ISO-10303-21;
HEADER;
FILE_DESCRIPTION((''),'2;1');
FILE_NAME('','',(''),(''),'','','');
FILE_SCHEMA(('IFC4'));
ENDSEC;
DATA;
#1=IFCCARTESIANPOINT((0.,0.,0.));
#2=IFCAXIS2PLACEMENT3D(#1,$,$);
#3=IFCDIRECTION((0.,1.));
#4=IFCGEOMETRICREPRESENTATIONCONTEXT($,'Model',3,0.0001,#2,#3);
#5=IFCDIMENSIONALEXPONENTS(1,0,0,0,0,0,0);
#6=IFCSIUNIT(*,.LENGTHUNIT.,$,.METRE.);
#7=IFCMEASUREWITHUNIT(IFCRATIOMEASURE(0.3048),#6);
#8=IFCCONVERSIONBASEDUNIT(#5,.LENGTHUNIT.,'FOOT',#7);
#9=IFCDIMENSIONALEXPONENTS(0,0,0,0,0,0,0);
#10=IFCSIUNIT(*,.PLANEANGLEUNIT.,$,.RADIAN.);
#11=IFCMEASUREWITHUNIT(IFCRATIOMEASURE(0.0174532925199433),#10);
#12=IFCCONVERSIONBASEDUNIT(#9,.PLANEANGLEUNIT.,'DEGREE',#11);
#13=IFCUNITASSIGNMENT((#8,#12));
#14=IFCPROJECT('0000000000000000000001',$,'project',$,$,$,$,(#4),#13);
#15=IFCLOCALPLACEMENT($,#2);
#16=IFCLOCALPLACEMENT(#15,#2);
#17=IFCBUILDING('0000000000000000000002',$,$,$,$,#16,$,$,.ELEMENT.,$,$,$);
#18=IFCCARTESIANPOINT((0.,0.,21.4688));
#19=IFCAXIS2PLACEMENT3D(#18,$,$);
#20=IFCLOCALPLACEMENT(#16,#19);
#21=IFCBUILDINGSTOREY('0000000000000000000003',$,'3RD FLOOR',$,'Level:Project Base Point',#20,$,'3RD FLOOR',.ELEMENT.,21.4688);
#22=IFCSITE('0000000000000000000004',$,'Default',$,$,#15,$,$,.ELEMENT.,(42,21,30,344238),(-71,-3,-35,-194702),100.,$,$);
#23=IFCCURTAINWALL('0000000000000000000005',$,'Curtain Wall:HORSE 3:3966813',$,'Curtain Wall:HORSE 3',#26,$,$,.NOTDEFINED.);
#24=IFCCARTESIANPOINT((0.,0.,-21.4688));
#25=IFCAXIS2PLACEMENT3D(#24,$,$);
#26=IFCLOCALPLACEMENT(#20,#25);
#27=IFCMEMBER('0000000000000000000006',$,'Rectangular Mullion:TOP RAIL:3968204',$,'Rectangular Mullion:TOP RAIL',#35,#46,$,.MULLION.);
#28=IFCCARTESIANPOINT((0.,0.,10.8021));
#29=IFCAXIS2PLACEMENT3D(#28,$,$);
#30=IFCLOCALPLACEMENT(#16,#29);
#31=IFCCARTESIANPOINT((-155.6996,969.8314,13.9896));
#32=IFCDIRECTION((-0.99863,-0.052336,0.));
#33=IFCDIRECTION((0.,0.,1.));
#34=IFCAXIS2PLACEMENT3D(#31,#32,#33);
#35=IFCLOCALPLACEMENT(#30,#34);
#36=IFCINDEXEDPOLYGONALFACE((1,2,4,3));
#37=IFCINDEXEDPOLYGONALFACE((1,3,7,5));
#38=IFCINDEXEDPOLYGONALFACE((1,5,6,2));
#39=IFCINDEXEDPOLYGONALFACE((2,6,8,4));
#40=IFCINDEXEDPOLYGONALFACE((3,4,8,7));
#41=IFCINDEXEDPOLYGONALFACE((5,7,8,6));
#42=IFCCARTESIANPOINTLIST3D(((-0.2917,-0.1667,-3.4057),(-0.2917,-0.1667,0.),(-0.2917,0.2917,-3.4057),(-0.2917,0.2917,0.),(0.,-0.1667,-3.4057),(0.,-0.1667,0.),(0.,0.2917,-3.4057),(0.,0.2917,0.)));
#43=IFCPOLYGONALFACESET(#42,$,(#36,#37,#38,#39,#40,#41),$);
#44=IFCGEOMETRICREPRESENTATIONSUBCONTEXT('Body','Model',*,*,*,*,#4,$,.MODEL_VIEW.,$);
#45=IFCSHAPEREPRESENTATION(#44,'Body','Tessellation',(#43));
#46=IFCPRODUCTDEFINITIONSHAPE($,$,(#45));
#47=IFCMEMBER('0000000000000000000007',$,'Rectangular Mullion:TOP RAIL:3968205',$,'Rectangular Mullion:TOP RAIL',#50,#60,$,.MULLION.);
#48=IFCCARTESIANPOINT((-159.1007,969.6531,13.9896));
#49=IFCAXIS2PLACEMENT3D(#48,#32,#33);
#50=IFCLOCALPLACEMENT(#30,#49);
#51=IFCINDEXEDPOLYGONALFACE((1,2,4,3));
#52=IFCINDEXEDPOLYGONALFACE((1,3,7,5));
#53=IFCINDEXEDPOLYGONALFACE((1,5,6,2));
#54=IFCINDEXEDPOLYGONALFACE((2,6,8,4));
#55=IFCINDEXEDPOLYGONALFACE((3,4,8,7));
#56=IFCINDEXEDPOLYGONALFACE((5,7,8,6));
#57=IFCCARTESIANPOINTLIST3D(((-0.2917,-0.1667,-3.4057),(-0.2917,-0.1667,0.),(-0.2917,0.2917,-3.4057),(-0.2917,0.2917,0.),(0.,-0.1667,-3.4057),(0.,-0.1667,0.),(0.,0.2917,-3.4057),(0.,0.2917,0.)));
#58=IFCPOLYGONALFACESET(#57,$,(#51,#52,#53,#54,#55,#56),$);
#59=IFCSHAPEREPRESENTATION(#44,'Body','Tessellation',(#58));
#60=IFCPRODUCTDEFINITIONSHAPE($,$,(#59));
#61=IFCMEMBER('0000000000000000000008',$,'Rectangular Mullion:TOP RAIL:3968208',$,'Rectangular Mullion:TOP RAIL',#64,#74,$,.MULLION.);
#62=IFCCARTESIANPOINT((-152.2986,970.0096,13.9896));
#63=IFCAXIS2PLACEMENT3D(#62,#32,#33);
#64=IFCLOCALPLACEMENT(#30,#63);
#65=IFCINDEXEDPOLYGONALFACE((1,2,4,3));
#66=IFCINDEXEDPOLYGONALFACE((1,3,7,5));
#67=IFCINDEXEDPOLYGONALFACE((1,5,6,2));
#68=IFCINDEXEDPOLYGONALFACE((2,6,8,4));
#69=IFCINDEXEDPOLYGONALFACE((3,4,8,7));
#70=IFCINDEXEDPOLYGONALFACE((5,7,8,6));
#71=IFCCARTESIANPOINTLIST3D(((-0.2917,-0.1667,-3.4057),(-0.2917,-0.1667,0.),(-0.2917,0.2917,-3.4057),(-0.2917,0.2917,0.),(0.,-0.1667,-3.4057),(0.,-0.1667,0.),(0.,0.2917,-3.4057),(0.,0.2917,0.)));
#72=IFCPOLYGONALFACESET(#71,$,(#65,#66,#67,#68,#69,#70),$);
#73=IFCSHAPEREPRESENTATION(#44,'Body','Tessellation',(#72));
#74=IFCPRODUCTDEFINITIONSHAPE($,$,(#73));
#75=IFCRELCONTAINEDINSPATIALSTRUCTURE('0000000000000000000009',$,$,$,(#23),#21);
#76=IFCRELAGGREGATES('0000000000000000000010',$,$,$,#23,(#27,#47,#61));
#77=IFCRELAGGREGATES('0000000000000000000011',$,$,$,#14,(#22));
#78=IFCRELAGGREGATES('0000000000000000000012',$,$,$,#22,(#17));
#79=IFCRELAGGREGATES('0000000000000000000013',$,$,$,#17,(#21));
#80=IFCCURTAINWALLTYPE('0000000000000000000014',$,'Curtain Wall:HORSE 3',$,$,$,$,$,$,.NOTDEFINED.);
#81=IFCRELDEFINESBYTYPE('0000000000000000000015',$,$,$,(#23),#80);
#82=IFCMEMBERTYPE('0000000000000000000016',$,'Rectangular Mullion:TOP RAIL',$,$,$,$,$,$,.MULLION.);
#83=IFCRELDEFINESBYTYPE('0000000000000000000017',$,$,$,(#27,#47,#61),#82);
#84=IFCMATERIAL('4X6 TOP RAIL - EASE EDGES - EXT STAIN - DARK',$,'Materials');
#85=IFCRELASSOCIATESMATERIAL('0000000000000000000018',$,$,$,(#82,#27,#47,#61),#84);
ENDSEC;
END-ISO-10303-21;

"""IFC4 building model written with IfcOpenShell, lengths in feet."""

from ifc_helpers import new_model, entity, si_unit, converted_unit, direction, frame, origin, origin_2d_with_axis, place, context, subcontext, project, spatial, rectangle, extrude, source, transform, mapped, material, material_profile, profile_set, profile_usage, type_object, type_shapes, element, aggregate, save


model = new_model("IFC4")

# Units and contexts
model_context = context("Model", 3, precision=0.0001, world=origin(), true_north=direction((0.0, 1.0)))
body_context = subcontext(model_context, "Body", "Model", "MODEL_VIEW")
ifc_project = project(units=[converted_unit("LENGTHUNIT", "FOOT", entity("IfcRatioMeasure", 0.3048), si_unit("LENGTHUNIT", "METRE"), dimensions=[1, 0, 0, 0, 0, 0, 0]), converted_unit("PLANEANGLEUNIT", "DEGREE", entity("IfcRatioMeasure", 0.0174532925199433), si_unit("PLANEANGLEUNIT", "RADIAN"), dimensions=[0, 0, 0, 0, 0, 0, 0])], contexts=[model_context])

# Site, building, storey
site_placement = place(None, origin())
site = spatial("IfcSite", under=ifc_project, at=site_placement, Name="Default", CompositionType="ELEMENT", RefLatitude=(42, 21, 30, 344238), RefLongitude=(-71, -3, -35, -194702), RefElevation=100.0)
building_placement = place(site_placement, origin())
building = spatial("IfcBuilding", under=site, at=building_placement, CompositionType="ELEMENT")
storey_placement = place(building_placement, frame((0.0, 0.0, 21.4688)))
storey = spatial("IfcBuildingStorey", under=building, at=storey_placement, Name="3RD FLOOR", ObjectType="Level:Project Base Point", LongName="3RD FLOOR", CompositionType="ELEMENT", Elevation=21.4688)

# Curtain wall
curtain_wall_type_1 = type_object("IfcCurtainWallType", Name="Curtain Wall:HORSE 3", PredefinedType="NOTDEFINED")
curtain_wall_1_placement = place(storey_placement, frame((0.0, 0.0, -21.4688)))
curtain_wall_1 = element("IfcCurtainWall", 1, at=curtain_wall_1_placement, inside=storey, type_object=curtain_wall_type_1, Name="Curtain Wall:HORSE 3:3966813", ObjectType="Curtain Wall:HORSE 3", PredefinedType="NOTDEFINED")

# Members
ifc_material_1 = material(Name="4X6 TOP RAIL - EASE EDGES - EXT STAIN - DARK", Category="Materials")
ifc_material_profile_1 = material_profile(ifc_material_1, rectangle(XDim=0.4583, YDim=0.2917, at=origin_2d_with_axis()), Name="TOP RAIL")
ifc_profile_set_1 = profile_set([ifc_material_profile_1], Name="TOP RAIL")
ifc_profile_usage_1 = profile_usage(ifc_profile_set_1)
member_type_1 = type_object("IfcMemberType", Name="Rectangular Mullion:TOP RAIL", PredefinedType="MULLION", material=ifc_profile_set_1)
shared_shape_1 = source(origin(), body_context, "Body", "SweptSolid", [
    extrude(rectangle(XDim=0.4583, YDim=0.2917, at=origin_2d_with_axis()), frame((-0.1458, 0.0625, -3.4057), z_axis=(0.0, 0.0, 1.0), x_axis=(0.0, -1.0, 0.0)), (0.0, 0.0, 1.0), 3.4057),
])
type_shapes(member_type_1, [shared_shape_1])
placement = place(building_placement, frame((0.0, 0.0, 10.8021)))
member_1_placement = place(placement, frame((-155.6996, 969.8314, 13.9896), z_axis=(-0.99863, -0.052336, 0.0), x_axis=(0.0, 0.0, 1.0)))
member_1 = element("IfcMember", 2, at=member_1_placement, type_object=member_type_1, material=ifc_profile_usage_1, Name="Rectangular Mullion:TOP RAIL:3968204", ObjectType="Rectangular Mullion:TOP RAIL", PredefinedType="MULLION", context=body_context, shape_type="MappedRepresentation", body=[
    mapped(shared_shape_1, transform((0.0, 0.0, 0.0), scale=1.0)),
])
ifc_profile_usage_2 = profile_usage(ifc_profile_set_1)
member_2_placement = place(placement, frame((-159.1007, 969.6531, 13.9896), z_axis=(-0.99863, -0.052336, 0.0), x_axis=(0.0, 0.0, 1.0)))
member_2 = element("IfcMember", 3, at=member_2_placement, type_object=member_type_1, material=ifc_profile_usage_2, Name="Rectangular Mullion:TOP RAIL:3968205", ObjectType="Rectangular Mullion:TOP RAIL", PredefinedType="MULLION", context=body_context, shape_type="MappedRepresentation", body=[
    mapped(shared_shape_1, transform((0.0, 0.0, 0.0), scale=1.0)),
])
ifc_profile_usage_3 = profile_usage(ifc_profile_set_1)
member_3_placement = place(placement, frame((-152.2986, 970.0096, 13.9896), z_axis=(-0.99863, -0.052336, 0.0), x_axis=(0.0, 0.0, 1.0)))
member_3 = element("IfcMember", 4, at=member_3_placement, type_object=member_type_1, material=ifc_profile_usage_3, Name="Rectangular Mullion:TOP RAIL:3968208", ObjectType="Rectangular Mullion:TOP RAIL", PredefinedType="MULLION", context=body_context, shape_type="MappedRepresentation", body=[
    mapped(shared_shape_1, transform((0.0, 0.0, 0.0), scale=1.0)),
])

aggregate(curtain_wall_1, [member_1, member_2, member_3])

save(model, "model.ifc")
